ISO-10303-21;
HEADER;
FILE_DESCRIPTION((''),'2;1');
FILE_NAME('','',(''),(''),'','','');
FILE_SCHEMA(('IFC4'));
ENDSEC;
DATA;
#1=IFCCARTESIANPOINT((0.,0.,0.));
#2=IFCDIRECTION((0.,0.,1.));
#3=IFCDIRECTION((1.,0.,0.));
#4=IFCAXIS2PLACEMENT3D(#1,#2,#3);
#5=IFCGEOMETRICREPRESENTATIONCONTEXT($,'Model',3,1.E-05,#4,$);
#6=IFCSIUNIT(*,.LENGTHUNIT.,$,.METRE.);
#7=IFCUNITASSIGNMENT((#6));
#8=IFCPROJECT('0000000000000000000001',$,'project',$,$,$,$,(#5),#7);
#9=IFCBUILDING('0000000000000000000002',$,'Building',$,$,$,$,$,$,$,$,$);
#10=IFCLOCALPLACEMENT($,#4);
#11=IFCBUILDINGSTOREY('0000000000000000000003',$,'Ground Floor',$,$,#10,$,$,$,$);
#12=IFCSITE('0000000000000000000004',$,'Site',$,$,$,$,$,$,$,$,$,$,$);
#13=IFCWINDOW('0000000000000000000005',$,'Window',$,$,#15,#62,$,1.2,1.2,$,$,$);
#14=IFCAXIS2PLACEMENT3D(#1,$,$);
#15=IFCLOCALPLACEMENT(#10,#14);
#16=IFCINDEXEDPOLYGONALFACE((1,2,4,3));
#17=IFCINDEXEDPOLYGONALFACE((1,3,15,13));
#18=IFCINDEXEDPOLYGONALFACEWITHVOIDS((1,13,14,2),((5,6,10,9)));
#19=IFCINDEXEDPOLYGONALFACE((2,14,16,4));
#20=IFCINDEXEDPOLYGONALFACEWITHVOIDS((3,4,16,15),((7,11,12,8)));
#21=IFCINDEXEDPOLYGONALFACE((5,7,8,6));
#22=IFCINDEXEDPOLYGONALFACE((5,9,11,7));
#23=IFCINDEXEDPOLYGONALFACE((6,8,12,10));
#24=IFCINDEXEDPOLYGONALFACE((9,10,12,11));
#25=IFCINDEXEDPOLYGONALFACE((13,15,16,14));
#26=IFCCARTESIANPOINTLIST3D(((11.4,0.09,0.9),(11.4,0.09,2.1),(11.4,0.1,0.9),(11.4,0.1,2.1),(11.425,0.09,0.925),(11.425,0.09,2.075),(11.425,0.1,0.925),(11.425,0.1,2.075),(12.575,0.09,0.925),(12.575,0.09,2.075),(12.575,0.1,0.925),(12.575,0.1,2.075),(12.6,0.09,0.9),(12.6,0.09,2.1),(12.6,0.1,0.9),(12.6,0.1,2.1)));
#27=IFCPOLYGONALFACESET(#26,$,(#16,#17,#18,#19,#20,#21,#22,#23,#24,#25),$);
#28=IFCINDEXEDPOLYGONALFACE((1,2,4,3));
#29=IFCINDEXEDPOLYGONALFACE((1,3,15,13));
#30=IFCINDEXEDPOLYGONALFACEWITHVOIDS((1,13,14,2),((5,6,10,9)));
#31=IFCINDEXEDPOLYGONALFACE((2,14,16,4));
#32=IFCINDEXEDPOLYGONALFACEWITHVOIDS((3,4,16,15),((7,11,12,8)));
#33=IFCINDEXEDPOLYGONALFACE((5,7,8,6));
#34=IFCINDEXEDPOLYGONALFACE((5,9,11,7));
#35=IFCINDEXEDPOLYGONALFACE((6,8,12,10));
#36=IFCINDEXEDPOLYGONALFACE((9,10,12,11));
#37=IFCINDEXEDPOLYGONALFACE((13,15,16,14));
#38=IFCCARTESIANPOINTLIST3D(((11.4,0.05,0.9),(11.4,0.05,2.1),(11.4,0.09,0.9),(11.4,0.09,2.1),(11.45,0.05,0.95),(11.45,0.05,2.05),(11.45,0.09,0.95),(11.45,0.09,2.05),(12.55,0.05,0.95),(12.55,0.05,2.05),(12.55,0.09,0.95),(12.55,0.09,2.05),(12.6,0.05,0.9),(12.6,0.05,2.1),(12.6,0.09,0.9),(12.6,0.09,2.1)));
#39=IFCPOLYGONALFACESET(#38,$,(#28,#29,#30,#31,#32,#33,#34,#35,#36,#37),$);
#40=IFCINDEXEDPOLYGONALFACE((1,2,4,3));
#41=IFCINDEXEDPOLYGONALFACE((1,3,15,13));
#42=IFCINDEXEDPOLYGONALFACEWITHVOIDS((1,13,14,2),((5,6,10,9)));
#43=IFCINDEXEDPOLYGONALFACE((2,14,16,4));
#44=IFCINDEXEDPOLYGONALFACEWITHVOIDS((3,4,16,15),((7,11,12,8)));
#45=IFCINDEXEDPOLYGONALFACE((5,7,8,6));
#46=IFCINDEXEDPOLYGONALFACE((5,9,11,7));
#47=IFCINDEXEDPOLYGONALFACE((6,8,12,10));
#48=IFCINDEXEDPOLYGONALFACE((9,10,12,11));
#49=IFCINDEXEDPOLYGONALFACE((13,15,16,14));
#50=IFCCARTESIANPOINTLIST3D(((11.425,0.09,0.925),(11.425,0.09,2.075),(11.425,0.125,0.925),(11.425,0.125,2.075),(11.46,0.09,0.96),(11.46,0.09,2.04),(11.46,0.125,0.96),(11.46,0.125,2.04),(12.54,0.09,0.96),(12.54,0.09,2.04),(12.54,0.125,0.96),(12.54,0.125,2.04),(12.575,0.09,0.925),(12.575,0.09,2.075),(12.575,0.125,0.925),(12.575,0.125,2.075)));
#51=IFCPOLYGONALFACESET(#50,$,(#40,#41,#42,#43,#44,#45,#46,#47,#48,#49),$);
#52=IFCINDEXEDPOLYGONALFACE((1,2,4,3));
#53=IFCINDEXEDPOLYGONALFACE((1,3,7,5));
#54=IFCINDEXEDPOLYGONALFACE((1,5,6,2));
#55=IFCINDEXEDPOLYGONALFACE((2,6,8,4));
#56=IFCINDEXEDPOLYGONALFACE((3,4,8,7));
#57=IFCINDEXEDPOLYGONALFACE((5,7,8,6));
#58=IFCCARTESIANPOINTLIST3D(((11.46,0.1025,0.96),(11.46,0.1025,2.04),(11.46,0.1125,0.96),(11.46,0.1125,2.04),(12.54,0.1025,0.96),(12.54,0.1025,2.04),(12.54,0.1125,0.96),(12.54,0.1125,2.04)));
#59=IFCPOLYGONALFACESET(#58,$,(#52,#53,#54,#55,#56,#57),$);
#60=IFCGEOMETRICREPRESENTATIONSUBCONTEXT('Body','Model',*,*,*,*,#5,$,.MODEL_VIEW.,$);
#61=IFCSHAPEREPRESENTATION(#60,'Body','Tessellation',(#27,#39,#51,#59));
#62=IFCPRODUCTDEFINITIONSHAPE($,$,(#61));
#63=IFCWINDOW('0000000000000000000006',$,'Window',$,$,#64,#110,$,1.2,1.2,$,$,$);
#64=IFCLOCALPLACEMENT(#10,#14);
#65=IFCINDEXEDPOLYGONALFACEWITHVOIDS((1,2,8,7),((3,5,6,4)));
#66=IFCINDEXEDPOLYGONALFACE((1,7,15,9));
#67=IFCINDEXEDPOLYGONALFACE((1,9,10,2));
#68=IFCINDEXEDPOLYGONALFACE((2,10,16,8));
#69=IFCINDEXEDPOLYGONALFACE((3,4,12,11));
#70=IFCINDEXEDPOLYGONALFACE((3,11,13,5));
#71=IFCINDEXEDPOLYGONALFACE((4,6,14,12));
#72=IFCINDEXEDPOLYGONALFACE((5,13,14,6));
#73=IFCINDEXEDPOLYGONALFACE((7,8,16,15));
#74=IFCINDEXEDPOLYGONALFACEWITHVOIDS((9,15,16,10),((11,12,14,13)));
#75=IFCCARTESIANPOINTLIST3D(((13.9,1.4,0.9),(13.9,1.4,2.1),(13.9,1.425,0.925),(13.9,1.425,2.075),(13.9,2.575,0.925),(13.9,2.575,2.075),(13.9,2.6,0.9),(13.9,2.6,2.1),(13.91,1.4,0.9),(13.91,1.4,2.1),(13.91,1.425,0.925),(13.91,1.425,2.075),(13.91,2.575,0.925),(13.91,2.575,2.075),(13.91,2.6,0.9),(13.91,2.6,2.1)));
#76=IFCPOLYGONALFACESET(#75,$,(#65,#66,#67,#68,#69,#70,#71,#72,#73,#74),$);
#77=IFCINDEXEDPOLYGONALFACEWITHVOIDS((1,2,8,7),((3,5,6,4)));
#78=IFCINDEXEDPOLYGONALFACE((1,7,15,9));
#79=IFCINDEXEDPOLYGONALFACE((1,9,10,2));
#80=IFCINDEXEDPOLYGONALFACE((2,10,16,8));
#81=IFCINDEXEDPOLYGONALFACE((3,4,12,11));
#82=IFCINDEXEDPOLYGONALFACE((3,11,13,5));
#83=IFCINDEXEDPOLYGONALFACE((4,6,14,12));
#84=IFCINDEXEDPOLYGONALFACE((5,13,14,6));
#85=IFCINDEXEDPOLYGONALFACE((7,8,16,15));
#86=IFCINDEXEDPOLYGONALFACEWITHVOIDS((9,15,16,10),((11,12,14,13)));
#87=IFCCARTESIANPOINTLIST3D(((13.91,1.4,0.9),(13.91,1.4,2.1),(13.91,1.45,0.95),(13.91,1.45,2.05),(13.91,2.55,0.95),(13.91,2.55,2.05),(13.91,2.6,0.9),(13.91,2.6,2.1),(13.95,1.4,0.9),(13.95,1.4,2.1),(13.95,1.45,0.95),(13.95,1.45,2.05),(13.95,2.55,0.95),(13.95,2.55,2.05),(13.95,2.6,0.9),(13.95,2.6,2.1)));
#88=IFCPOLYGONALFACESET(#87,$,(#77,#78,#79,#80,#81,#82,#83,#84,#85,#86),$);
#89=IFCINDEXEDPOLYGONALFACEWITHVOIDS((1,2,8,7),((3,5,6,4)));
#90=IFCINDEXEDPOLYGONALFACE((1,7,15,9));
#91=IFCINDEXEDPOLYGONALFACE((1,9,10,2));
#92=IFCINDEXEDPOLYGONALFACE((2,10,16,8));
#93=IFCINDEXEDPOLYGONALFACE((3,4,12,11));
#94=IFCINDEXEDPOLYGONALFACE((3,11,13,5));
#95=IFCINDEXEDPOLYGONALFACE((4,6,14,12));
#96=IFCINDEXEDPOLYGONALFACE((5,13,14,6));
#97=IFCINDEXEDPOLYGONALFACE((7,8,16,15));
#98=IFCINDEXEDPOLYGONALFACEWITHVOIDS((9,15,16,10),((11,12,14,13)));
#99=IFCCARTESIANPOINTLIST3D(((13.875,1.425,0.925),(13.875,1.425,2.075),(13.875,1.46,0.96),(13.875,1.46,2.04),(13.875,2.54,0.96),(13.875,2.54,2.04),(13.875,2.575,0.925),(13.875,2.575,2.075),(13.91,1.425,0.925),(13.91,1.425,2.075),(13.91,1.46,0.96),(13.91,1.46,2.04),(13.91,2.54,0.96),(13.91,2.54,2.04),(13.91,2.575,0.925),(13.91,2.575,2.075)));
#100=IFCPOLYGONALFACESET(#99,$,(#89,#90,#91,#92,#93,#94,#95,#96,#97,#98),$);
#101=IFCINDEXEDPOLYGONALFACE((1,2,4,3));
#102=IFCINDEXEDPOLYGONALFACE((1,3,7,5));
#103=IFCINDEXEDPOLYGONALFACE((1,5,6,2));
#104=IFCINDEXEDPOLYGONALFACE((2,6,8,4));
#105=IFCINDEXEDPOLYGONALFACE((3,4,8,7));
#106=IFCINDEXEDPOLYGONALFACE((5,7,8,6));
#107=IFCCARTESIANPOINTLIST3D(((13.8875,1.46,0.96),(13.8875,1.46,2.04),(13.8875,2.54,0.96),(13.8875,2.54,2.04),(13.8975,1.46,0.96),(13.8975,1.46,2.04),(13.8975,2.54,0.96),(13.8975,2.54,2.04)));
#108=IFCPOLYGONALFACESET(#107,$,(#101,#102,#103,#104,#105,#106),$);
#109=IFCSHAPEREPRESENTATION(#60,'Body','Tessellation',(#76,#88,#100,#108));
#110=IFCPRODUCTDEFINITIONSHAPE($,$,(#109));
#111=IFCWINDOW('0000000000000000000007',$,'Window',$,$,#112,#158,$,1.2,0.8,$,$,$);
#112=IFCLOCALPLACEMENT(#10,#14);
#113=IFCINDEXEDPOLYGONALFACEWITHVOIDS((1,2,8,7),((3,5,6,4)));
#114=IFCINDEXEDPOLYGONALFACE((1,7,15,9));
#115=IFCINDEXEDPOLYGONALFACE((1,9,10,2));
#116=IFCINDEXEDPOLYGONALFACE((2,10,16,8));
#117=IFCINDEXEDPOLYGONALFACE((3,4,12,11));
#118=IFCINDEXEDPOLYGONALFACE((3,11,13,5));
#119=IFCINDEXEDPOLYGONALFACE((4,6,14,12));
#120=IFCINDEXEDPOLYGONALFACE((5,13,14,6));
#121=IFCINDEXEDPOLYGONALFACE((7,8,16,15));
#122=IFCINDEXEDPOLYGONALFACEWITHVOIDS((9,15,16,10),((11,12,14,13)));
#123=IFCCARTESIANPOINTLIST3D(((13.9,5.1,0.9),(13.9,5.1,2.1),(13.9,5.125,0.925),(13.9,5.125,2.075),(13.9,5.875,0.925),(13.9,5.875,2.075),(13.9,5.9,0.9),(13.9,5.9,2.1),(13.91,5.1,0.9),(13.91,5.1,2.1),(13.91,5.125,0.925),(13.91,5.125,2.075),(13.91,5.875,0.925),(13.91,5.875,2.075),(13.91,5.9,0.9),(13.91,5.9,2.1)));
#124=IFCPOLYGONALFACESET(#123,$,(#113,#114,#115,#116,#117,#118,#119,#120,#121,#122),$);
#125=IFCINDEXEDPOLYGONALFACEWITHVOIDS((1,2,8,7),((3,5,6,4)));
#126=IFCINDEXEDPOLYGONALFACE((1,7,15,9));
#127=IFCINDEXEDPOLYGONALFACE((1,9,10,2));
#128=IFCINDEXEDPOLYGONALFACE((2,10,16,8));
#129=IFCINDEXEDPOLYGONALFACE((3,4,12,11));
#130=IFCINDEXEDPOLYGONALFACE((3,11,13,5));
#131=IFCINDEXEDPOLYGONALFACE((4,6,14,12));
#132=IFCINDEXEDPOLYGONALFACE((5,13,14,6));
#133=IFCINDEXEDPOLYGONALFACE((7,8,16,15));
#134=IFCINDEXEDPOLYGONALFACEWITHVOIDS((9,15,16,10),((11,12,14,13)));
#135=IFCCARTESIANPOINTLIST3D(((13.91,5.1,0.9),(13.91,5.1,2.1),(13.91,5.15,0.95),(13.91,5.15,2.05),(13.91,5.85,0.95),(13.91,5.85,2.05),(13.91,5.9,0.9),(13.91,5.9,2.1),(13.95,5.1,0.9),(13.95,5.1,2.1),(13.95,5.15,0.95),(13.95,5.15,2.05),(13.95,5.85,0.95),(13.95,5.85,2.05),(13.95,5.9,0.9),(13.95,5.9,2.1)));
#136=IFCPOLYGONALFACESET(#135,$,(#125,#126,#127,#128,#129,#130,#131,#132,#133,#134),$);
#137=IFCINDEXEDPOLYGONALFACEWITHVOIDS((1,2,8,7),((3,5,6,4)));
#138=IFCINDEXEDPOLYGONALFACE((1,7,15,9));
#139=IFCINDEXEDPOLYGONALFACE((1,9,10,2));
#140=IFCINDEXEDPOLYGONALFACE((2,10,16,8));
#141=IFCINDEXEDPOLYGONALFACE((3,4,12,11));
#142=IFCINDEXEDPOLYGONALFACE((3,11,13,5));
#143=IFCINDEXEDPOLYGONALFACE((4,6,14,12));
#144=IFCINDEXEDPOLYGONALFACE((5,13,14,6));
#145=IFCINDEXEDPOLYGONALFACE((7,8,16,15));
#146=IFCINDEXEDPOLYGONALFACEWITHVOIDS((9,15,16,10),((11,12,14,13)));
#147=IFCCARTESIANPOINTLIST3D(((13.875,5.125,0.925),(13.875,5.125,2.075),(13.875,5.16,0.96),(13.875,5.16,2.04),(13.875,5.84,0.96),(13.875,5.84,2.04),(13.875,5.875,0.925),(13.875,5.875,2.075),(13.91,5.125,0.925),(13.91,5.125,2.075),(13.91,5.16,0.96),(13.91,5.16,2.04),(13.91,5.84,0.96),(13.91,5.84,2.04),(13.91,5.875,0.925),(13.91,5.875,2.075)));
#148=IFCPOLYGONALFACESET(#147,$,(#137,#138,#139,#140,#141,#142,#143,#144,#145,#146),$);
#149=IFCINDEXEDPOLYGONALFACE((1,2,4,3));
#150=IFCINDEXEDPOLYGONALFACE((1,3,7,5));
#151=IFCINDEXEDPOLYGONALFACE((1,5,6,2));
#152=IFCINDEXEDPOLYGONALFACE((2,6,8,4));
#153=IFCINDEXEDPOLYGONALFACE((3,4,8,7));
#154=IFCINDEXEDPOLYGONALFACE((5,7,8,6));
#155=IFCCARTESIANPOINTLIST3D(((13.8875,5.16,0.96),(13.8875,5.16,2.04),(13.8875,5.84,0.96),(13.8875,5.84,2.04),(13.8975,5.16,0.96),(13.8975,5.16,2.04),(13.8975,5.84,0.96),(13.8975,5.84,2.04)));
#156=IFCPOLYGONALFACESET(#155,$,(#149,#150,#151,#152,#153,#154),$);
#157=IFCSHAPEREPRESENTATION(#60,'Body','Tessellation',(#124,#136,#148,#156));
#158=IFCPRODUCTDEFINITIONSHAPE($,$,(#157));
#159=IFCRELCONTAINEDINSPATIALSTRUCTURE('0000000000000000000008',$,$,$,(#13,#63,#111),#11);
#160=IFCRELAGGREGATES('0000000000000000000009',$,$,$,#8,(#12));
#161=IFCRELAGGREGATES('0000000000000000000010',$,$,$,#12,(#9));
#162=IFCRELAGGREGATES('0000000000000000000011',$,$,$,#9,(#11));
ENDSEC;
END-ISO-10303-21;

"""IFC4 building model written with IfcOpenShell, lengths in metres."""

from ifc_helpers import new_model, si_unit, frame, origin_with_axes, place, context, subcontext, project, spatial, line, indexed_curve, outline, extrude, element, save


model = new_model("IFC4")

# Units and contexts
model_context = context("Model", 3, precision=1e-05, world=origin_with_axes())
body_context = subcontext(model_context, "Body", "Model", "MODEL_VIEW")
ifc_project = project(units=[si_unit("LENGTHUNIT", "METRE")], contexts=[model_context])

# Site, building, storey
site = spatial("IfcSite", under=ifc_project, Name="Site")
building = spatial("IfcBuilding", under=site, Name="Building")
storey_placement = place(None, origin_with_axes())
storey = spatial("IfcBuildingStorey", under=building, at=storey_placement, Name="Ground Floor")

# Windows
for number, where, z_axis, x_axis, name in (
    (1, (11.4, 0.0, 0.9), (0.0, 0.0, 1.0), (1.0, 0.0, 0.0), "Window"),
    (2, (14.0, 1.4, 0.9), (0.0, 0.0, 1.0), (0.0, 1.0, 0.0), "Window"),
):
    element("IfcWindow", number, at=place(storey_placement, frame(where, z_axis=z_axis, x_axis=x_axis)), inside=storey, Name=name, OverallHeight=1.2, OverallWidth=1.2, context=body_context, shape_type="SweptSolid", body=[
        extrude(outline(indexed_curve([(0.0, 0.0), (1.2, 0.0), (1.2, 1.2), (0.0, 1.2)], segments=[line(1, 2, 3, 4, 1)]), holes=[indexed_curve([(0.025, 0.025), (1.175, 0.025), (1.175, 1.175), (0.025, 1.175)], segments=[line(1, 2, 3, 4, 1)])]), frame((0.0, 0.09, 0.0), z_axis=(0.0, -1.0, 0.0), x_axis=(1.0, 0.0, 0.0)), (0.0, 0.0, -1.0), 0.01),
        extrude(outline(indexed_curve([(0.0, 0.0), (1.2, 0.0), (1.2, 1.2), (0.0, 1.2)], segments=[line(1, 2, 3, 4, 1)]), holes=[indexed_curve([(0.05, 0.05), (1.15, 0.05), (1.15, 1.15), (0.05, 1.15)], segments=[line(1, 2, 3, 4, 1)])]), frame((0.0, 0.05, 0.0), z_axis=(0.0, -1.0, 0.0), x_axis=(1.0, 0.0, 0.0)), (0.0, 0.0, -1.0), 0.04),
        extrude(outline(indexed_curve([(0.0, 0.0), (1.15, 0.0), (1.15, 1.15), (0.0, 1.15)], segments=[line(1, 2, 3, 4, 1)]), holes=[indexed_curve([(0.035, 0.035), (1.115, 0.035), (1.115, 1.115), (0.035, 1.115)], segments=[line(1, 2, 3, 4, 1)])]), frame((0.025, 0.09, 0.025), z_axis=(0.0, -1.0, 0.0), x_axis=(1.0, 0.0, 0.0)), (0.0, 0.0, -1.0), 0.035),
        extrude(outline(indexed_curve([(0.035, 0.035), (1.115, 0.035), (1.115, 1.115), (0.035, 1.115)], segments=[line(1, 2, 3, 4, 1)])), frame((0.025, 0.1025, 0.025), z_axis=(0.0, -1.0, 0.0), x_axis=(1.0, 0.0, 0.0)), (0.0, 0.0, -1.0), 0.01),
    ])
window_placement = place(storey_placement, frame((14.0, 5.1, 0.9), z_axis=(0.0, 0.0, 1.0), x_axis=(0.0, 1.0, 0.0)))
element("IfcWindow", 3, at=window_placement, inside=storey, Name="Window", OverallHeight=1.2, OverallWidth=0.8, context=body_context, shape_type="SweptSolid", body=[
    extrude(outline(indexed_curve([(0.0, 0.0), (0.8, 0.0), (0.8, 1.2), (0.0, 1.2)], segments=[line(1, 2, 3, 4, 1)]), holes=[indexed_curve([(0.025, 0.025), (0.775, 0.025), (0.775, 1.175), (0.025, 1.175)], segments=[line(1, 2, 3, 4, 1)])]), frame((0.0, 0.09, 0.0), z_axis=(0.0, -1.0, 0.0), x_axis=(1.0, 0.0, 0.0)), (0.0, 0.0, -1.0), 0.01),
    extrude(outline(indexed_curve([(0.0, 0.0), (0.8, 0.0), (0.8, 1.2), (0.0, 1.2)], segments=[line(1, 2, 3, 4, 1)]), holes=[indexed_curve([(0.05, 0.05), (0.75, 0.05), (0.75, 1.15), (0.05, 1.15)], segments=[line(1, 2, 3, 4, 1)])]), frame((0.0, 0.05, 0.0), z_axis=(0.0, -1.0, 0.0), x_axis=(1.0, 0.0, 0.0)), (0.0, 0.0, -1.0), 0.04),
    extrude(outline(indexed_curve([(0.0, 0.0), (0.75, 0.0), (0.75, 1.15), (0.0, 1.15)], segments=[line(1, 2, 3, 4, 1)]), holes=[indexed_curve([(0.035, 0.035), (0.715, 0.035), (0.715, 1.115), (0.035, 1.115)], segments=[line(1, 2, 3, 4, 1)])]), frame((0.025, 0.09, 0.025), z_axis=(0.0, -1.0, 0.0), x_axis=(1.0, 0.0, 0.0)), (0.0, 0.0, -1.0), 0.035),
    extrude(outline(indexed_curve([(0.035, 0.035), (0.715, 0.035), (0.715, 1.115), (0.035, 1.115)], segments=[line(1, 2, 3, 4, 1)])), frame((0.025, 0.1025, 0.025), z_axis=(0.0, -1.0, 0.0), x_axis=(1.0, 0.0, 0.0)), (0.0, 0.0, -1.0), 0.01),
])

save(model, "model.ifc")
